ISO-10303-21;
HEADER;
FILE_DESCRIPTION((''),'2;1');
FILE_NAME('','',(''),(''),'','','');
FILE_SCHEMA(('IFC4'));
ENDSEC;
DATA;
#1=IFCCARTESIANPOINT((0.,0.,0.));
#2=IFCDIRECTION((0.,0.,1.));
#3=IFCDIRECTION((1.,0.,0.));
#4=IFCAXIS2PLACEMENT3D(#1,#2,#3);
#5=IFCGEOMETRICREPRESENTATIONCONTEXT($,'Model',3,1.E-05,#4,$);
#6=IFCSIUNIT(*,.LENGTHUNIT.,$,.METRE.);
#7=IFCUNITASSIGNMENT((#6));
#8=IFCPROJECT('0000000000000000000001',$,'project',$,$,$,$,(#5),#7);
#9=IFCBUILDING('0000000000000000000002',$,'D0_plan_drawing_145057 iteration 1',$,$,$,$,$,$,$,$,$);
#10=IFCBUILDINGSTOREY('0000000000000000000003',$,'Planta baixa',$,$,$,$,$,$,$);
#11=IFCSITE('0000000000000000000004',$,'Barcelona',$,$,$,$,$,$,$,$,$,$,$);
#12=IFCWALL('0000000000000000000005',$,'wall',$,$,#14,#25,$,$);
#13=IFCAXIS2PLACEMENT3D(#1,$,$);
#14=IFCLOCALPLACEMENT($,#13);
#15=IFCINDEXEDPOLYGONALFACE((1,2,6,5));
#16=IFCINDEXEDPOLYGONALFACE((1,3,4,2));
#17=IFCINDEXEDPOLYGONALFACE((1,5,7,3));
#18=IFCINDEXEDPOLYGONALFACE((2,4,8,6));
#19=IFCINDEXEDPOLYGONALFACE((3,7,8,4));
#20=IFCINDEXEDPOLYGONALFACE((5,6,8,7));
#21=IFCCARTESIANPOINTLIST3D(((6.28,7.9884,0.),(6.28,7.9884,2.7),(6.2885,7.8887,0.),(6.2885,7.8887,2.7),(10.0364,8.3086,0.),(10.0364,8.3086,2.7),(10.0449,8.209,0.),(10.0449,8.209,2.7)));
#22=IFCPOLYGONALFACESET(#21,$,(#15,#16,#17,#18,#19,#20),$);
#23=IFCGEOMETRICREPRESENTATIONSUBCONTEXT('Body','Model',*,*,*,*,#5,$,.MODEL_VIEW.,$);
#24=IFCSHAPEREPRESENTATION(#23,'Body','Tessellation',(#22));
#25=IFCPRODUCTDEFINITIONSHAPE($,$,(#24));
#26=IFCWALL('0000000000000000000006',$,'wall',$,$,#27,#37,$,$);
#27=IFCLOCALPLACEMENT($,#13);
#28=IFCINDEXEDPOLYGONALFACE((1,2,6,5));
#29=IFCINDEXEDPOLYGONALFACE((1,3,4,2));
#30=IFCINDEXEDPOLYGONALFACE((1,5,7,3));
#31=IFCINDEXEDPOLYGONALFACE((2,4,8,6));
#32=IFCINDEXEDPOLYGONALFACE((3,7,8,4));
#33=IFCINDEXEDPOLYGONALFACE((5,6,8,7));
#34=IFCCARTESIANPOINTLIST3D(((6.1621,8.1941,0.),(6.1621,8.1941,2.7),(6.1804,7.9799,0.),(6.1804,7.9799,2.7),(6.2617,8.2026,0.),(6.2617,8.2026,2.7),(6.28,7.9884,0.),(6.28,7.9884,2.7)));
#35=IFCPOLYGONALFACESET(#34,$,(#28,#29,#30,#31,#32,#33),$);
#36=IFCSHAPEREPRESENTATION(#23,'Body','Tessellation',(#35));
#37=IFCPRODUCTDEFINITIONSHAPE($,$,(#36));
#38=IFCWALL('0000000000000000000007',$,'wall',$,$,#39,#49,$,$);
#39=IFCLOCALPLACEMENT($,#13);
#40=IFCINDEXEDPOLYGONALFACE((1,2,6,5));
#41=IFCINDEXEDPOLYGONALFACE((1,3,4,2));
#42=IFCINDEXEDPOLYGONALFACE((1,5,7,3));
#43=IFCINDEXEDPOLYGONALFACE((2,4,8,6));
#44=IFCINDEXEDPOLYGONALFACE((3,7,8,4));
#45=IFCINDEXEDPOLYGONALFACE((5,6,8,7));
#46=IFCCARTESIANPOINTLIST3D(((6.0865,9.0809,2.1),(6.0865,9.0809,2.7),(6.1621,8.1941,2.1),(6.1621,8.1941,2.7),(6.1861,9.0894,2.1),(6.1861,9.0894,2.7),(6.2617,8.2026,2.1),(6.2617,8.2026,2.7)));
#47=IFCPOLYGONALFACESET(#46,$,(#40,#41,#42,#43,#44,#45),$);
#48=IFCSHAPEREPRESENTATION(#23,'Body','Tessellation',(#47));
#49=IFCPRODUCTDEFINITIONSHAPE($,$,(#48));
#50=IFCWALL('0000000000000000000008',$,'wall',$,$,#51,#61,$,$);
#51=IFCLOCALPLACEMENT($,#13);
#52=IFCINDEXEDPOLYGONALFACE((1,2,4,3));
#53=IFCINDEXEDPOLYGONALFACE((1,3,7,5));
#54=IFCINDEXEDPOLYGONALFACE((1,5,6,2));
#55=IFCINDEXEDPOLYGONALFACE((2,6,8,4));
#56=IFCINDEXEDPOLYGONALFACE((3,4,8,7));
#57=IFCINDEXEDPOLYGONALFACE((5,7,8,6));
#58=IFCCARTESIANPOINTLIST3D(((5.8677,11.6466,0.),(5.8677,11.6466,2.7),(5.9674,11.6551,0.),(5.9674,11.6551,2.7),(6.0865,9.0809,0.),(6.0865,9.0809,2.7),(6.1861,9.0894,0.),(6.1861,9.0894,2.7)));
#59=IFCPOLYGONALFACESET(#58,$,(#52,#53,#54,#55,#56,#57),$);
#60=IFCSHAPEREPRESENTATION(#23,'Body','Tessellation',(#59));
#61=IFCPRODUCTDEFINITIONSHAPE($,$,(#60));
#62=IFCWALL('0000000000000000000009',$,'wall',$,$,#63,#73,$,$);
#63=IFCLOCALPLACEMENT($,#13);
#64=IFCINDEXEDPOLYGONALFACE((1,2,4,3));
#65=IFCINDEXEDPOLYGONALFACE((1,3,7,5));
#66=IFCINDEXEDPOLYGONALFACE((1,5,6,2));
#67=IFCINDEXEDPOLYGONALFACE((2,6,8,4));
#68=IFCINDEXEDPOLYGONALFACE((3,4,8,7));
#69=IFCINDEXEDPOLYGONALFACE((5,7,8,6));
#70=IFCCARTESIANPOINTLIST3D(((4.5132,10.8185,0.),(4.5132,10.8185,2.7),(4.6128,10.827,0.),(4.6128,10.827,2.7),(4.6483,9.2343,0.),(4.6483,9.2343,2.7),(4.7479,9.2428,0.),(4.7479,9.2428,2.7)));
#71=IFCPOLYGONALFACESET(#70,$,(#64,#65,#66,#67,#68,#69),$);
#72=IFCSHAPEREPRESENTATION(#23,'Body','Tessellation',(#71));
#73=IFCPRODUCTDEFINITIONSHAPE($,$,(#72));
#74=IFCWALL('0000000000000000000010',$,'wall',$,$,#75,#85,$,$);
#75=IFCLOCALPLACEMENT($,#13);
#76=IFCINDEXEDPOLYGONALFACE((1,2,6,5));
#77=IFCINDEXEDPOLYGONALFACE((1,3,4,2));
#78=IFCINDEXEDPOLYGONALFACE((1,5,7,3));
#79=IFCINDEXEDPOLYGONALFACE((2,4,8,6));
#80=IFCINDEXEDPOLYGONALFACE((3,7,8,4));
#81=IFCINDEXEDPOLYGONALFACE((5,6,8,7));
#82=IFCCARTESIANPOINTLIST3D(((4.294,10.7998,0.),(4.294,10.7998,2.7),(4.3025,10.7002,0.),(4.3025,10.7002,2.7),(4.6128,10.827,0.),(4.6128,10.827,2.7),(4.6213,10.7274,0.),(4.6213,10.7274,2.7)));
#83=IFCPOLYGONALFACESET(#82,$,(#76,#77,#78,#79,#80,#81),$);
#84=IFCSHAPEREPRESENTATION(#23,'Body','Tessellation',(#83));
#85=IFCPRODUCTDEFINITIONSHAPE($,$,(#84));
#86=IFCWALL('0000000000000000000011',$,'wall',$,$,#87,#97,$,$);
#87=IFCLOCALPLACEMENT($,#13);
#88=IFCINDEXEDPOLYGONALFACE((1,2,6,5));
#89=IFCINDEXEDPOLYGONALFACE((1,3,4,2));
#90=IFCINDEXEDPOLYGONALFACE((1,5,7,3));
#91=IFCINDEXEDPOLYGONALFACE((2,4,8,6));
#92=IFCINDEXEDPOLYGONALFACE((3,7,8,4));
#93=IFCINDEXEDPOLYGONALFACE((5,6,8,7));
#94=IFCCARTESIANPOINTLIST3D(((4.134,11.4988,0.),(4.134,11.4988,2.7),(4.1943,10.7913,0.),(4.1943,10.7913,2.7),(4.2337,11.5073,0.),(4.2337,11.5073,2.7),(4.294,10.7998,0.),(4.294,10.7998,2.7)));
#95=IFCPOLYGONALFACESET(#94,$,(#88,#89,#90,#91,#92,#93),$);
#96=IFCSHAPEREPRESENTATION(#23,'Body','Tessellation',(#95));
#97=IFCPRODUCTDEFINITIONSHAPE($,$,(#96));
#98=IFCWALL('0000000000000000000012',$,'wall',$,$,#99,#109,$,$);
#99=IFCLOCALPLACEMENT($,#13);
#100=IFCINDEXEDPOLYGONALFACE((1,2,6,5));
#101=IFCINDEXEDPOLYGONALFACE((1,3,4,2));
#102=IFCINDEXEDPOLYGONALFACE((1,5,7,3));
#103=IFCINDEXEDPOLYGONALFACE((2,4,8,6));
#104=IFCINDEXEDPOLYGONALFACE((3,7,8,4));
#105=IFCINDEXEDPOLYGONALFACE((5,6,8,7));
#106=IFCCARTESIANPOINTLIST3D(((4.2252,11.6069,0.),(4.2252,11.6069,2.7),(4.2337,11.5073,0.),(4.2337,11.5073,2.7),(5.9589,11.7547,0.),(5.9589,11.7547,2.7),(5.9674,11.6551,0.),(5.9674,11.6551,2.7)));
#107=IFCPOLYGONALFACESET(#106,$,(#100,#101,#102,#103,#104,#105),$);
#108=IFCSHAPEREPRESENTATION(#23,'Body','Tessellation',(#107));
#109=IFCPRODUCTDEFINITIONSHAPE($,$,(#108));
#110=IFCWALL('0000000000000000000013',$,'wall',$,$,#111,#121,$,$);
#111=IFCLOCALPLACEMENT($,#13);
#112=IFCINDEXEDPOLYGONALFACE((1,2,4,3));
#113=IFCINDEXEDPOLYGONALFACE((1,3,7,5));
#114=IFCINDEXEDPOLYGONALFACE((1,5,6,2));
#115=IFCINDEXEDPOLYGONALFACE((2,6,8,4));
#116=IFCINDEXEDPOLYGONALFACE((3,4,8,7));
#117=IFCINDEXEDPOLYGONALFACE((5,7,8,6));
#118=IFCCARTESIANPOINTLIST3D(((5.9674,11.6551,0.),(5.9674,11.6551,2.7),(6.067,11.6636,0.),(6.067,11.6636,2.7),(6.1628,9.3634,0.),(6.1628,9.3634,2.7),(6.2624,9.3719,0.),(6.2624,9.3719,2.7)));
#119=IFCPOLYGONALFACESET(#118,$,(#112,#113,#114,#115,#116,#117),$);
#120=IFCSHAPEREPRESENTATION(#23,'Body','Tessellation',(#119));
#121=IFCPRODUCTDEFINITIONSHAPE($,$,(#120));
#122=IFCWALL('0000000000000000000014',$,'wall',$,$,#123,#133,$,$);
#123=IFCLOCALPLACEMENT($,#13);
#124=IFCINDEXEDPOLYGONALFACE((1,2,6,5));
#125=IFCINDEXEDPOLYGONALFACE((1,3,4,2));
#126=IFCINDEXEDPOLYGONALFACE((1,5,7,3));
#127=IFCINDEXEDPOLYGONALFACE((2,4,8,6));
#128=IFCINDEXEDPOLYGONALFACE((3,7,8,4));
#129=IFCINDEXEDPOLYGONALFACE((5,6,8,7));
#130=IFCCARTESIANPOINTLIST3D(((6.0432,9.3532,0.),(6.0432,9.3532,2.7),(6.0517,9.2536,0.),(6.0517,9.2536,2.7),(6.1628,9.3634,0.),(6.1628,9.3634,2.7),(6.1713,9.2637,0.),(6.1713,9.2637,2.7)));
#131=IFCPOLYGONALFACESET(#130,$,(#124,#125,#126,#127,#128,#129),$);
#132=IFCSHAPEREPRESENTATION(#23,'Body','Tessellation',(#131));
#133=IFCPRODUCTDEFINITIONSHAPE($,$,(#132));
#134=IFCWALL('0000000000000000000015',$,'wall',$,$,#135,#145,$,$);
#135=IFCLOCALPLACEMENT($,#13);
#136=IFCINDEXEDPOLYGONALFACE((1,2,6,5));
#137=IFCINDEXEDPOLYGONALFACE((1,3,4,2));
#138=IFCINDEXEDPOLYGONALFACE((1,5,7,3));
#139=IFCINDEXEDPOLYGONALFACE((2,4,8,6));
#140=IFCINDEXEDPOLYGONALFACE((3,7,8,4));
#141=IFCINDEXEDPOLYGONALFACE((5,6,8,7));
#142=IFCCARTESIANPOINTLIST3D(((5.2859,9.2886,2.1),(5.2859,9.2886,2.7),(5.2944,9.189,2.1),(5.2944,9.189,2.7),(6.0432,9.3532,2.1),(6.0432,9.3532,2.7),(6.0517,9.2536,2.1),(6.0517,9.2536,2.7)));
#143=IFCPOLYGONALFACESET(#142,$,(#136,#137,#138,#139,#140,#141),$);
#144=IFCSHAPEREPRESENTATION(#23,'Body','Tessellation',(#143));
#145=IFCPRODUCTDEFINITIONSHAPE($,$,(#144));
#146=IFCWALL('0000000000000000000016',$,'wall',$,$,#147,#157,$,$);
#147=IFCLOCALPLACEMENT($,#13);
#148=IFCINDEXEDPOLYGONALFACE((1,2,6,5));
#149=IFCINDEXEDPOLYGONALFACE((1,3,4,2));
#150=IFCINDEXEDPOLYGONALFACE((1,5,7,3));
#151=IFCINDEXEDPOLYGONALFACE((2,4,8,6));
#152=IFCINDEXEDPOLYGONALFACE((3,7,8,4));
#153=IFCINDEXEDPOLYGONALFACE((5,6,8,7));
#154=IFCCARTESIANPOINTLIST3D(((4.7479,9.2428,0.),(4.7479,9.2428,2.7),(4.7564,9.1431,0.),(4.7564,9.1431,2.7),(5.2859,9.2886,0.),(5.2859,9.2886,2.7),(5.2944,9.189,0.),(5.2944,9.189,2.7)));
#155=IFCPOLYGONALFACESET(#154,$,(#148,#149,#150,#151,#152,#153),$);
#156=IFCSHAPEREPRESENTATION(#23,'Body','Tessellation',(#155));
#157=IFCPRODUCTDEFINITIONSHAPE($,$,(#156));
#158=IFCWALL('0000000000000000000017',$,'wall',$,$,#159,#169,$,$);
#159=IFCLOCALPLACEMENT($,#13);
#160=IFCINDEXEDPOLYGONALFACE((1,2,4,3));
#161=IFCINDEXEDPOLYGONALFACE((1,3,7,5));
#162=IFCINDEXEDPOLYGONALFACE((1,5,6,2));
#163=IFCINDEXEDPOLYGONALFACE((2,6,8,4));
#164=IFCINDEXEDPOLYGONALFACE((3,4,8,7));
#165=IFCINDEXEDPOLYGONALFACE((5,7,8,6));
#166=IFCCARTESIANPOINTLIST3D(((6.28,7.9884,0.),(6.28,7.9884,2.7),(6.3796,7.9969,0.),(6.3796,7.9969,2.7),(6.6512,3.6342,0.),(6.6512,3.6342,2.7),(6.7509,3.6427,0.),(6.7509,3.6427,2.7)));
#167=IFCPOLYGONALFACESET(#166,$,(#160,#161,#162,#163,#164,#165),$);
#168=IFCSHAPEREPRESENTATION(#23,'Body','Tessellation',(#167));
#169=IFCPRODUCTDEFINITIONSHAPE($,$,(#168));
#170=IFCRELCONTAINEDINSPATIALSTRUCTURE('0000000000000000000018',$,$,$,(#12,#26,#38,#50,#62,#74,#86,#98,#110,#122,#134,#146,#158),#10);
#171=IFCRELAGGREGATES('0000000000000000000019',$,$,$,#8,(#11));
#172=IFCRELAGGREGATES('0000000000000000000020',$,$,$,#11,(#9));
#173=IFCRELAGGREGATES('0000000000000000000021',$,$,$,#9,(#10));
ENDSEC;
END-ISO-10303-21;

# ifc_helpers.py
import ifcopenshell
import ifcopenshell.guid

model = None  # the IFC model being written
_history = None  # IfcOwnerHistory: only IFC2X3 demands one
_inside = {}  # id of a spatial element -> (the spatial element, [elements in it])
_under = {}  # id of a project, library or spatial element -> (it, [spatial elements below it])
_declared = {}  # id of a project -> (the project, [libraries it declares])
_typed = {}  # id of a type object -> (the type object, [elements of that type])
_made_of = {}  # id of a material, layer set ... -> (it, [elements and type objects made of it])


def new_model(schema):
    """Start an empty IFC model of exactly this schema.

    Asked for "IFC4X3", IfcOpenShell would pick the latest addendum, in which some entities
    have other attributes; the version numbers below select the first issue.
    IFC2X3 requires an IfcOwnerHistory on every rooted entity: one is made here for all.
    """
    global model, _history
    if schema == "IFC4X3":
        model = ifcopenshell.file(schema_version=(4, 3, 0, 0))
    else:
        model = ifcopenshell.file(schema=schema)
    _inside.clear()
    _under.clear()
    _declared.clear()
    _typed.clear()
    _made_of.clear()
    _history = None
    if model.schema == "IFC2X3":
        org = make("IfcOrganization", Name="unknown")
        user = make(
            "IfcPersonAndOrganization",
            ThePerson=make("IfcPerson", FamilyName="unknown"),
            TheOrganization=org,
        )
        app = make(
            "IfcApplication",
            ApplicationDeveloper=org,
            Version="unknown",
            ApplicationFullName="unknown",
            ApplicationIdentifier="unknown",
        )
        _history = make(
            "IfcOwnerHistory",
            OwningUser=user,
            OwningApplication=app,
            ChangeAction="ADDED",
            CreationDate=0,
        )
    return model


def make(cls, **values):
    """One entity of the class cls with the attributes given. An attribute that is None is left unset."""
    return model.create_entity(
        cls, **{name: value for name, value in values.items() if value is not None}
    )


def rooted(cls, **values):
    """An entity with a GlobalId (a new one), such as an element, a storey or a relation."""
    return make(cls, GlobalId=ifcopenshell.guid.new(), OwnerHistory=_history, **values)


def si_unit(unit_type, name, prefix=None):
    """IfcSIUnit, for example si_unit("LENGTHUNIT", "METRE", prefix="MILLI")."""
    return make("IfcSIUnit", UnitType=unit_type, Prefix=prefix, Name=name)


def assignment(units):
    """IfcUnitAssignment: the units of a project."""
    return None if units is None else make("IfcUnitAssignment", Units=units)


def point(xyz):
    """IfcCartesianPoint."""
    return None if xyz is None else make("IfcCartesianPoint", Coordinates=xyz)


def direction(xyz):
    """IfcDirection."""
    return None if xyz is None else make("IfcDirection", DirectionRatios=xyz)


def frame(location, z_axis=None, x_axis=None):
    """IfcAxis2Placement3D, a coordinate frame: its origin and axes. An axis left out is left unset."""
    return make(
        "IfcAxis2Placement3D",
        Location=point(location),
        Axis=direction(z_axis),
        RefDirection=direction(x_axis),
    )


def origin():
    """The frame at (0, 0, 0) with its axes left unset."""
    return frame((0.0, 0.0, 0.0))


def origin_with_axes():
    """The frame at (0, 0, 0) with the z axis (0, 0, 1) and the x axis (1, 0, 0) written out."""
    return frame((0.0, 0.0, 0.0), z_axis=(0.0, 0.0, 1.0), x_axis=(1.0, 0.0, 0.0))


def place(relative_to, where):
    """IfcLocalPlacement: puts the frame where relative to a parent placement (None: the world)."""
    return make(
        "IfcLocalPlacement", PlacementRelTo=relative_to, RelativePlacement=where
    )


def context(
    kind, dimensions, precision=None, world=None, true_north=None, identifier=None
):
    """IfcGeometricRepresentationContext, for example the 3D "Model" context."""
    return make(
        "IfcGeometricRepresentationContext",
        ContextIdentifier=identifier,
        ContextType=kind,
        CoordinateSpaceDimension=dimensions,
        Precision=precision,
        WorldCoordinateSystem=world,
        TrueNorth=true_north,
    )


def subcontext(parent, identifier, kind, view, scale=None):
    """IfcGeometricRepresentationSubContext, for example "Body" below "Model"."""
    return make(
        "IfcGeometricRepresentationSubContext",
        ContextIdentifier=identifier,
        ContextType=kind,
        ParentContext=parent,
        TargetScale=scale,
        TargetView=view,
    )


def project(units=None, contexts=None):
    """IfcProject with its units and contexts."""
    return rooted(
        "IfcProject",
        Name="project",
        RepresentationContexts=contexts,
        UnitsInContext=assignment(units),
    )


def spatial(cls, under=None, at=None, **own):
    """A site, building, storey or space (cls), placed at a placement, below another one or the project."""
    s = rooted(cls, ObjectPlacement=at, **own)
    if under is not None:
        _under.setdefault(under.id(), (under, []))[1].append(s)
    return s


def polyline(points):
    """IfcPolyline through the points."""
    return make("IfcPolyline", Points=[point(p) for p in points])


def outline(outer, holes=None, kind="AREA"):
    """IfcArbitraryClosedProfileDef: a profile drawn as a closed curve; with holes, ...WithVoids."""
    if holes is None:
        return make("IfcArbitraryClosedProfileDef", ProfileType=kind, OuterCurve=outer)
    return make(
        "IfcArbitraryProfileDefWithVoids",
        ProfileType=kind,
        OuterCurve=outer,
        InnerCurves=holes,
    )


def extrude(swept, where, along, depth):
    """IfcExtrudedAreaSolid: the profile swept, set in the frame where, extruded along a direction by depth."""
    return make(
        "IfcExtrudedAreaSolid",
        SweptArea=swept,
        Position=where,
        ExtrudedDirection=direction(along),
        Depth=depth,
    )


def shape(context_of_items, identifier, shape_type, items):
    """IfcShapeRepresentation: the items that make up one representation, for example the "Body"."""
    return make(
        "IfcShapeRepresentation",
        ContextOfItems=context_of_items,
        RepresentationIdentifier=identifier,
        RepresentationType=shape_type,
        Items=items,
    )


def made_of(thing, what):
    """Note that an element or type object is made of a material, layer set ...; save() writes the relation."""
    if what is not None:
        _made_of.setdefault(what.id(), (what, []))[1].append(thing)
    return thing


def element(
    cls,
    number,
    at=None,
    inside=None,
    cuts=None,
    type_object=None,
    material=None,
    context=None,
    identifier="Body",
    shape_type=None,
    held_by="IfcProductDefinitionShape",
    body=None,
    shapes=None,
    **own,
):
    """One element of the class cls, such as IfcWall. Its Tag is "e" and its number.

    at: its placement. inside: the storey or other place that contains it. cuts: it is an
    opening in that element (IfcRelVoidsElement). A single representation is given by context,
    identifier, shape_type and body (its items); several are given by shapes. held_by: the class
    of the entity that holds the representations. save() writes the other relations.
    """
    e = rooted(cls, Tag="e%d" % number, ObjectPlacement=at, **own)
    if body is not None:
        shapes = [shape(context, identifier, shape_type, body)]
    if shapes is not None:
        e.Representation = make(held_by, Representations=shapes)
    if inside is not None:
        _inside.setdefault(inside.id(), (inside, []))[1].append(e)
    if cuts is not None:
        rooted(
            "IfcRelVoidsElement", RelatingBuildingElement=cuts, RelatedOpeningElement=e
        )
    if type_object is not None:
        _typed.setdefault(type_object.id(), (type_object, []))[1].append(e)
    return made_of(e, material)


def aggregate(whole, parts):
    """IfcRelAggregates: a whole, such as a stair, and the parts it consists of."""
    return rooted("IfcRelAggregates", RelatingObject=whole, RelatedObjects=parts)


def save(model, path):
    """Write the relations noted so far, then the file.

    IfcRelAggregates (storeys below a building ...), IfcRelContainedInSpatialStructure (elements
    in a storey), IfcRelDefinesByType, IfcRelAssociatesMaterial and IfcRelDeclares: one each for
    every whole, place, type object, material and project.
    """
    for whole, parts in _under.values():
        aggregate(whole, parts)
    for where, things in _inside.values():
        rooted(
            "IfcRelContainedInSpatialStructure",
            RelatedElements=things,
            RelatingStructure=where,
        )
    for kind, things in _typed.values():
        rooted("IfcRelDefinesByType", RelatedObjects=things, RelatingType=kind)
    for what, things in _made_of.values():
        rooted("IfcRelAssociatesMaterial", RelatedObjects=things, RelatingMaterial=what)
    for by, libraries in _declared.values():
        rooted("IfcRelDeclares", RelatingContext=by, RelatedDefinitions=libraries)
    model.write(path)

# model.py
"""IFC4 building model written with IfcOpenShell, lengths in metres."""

from ifc_helpers import new_model, si_unit, frame, origin, origin_with_axes, place, context, subcontext, project, spatial, polyline, outline, extrude, element, save


model = new_model("IFC4")

# Units and contexts
model_context = context("Model", 3, precision=1e-05, world=origin_with_axes())
body_context = subcontext(model_context, "Body", "Model", "MODEL_VIEW")
ifc_project = project(units=[si_unit("LENGTHUNIT", "METRE")], contexts=[model_context])

# Site, building, storey
site = spatial("IfcSite", under=ifc_project, Name="Barcelona")
building = spatial("IfcBuilding", under=site, Name="D0_plan_drawing_145057 iteration 1")
storey = spatial("IfcBuildingStorey", under=building, Name="Planta baixa")

# Walls
wall_1_placement = place(None, origin_with_axes())
element("IfcWall", 1, at=wall_1_placement, inside=storey, Name="wall", context=body_context, shape_type="SweptSolid", body=[
    extrude(outline(polyline([(10.0449, 8.209), (6.2885, 7.8887), (6.28, 7.9884), (10.0364, 8.3086), (10.0449, 8.209)])), origin(), (0.0, 0.0, 1.0), 2.7),
])
wall_2_placement = place(None, origin_with_axes())
element("IfcWall", 2, at=wall_2_placement, inside=storey, Name="wall", context=body_context, shape_type="SweptSolid", body=[
    extrude(outline(polyline([(6.1804, 7.9799), (6.1621, 8.1941), (6.2617, 8.2026), (6.28, 7.9884), (6.1804, 7.9799)])), origin(), (0.0, 0.0, 1.0), 2.7),
])
wall_3_placement = place(None, origin_with_axes())
element("IfcWall", 3, at=wall_3_placement, inside=storey, Name="wall", context=body_context, shape_type="SweptSolid", body=[
    extrude(outline(polyline([(6.1621, 8.1941), (6.0865, 9.0809), (6.1861, 9.0894), (6.2617, 8.2026), (6.1621, 8.1941)])), frame((0.0, 0.0, 2.1)), (0.0, 0.0, 1.0), 0.6),
])
wall_4_placement = place(None, origin_with_axes())
element("IfcWall", 4, at=wall_4_placement, inside=storey, Name="wall", context=body_context, shape_type="SweptSolid", body=[
    extrude(outline(polyline([(6.0865, 9.0809), (5.8677, 11.6466), (5.9674, 11.6551), (6.1861, 9.0894), (6.0865, 9.0809)])), origin(), (0.0, 0.0, 1.0), 2.7),
])
wall_5_placement = place(None, origin_with_axes())
element("IfcWall", 5, at=wall_5_placement, inside=storey, Name="wall", context=body_context, shape_type="SweptSolid", body=[
    extrude(outline(polyline([(4.6483, 9.2343), (4.5132, 10.8185), (4.6128, 10.827), (4.7479, 9.2428), (4.6483, 9.2343)])), origin(), (0.0, 0.0, 1.0), 2.7),
])
wall_6_placement = place(None, origin_with_axes())
element("IfcWall", 6, at=wall_6_placement, inside=storey, Name="wall", context=body_context, shape_type="SweptSolid", body=[
    extrude(outline(polyline([(4.6213, 10.7274), (4.3025, 10.7002), (4.294, 10.7998), (4.6128, 10.827), (4.6213, 10.7274)])), origin(), (0.0, 0.0, 1.0), 2.7),
])
wall_7_placement = place(None, origin_with_axes())
element("IfcWall", 7, at=wall_7_placement, inside=storey, Name="wall", context=body_context, shape_type="SweptSolid", body=[
    extrude(outline(polyline([(4.1943, 10.7913), (4.134, 11.4988), (4.2337, 11.5073), (4.294, 10.7998), (4.1943, 10.7913)])), origin(), (0.0, 0.0, 1.0), 2.7),
])
wall_8_placement = place(None, origin_with_axes())
element("IfcWall", 8, at=wall_8_placement, inside=storey, Name="wall", context=body_context, shape_type="SweptSolid", body=[
    extrude(outline(polyline([(4.2252, 11.6069), (5.9589, 11.7547), (5.9674, 11.6551), (4.2337, 11.5073), (4.2252, 11.6069)])), origin(), (0.0, 0.0, 1.0), 2.7),
])
wall_9_placement = place(None, origin_with_axes())
element("IfcWall", 9, at=wall_9_placement, inside=storey, Name="wall", context=body_context, shape_type="SweptSolid", body=[
    extrude(outline(polyline([(6.067, 11.6636), (6.2624, 9.3719), (6.1628, 9.3634), (5.9674, 11.6551), (6.067, 11.6636)])), origin(), (0.0, 0.0, 1.0), 2.7),
])
wall_10_placement = place(None, origin_with_axes())
element("IfcWall", 10, at=wall_10_placement, inside=storey, Name="wall", context=body_context, shape_type="SweptSolid", body=[
    extrude(outline(polyline([(6.1713, 9.2637), (6.0517, 9.2536), (6.0432, 9.3532), (6.1628, 9.3634), (6.1713, 9.2637)])), origin(), (0.0, 0.0, 1.0), 2.7),
])
wall_11_placement = place(None, origin_with_axes())
element("IfcWall", 11, at=wall_11_placement, inside=storey, Name="wall", context=body_context, shape_type="SweptSolid", body=[
    extrude(outline(polyline([(6.0517, 9.2536), (5.2944, 9.189), (5.2859, 9.2886), (6.0432, 9.3532), (6.0517, 9.2536)])), frame((0.0, 0.0, 2.1)), (0.0, 0.0, 1.0), 0.6),
])
wall_12_placement = place(None, origin_with_axes())
element("IfcWall", 12, at=wall_12_placement, inside=storey, Name="wall", context=body_context, shape_type="SweptSolid", body=[
    extrude(outline(polyline([(5.2944, 9.189), (4.7564, 9.1431), (4.7479, 9.2428), (5.2859, 9.2886), (5.2944, 9.189)])), origin(), (0.0, 0.0, 1.0), 2.7),
])
wall_13_placement = place(None, origin_with_axes())
element("IfcWall", 13, at=wall_13_placement, inside=storey, Name="wall", context=body_context, shape_type="SweptSolid", body=[
    extrude(outline(polyline([(6.3796, 7.9969), (6.7509, 3.6427), (6.6512, 3.6342), (6.28, 7.9884), (6.3796, 7.9969)])), origin(), (0.0, 0.0, 1.0), 2.7),
])

save(model, "model.ifc")
